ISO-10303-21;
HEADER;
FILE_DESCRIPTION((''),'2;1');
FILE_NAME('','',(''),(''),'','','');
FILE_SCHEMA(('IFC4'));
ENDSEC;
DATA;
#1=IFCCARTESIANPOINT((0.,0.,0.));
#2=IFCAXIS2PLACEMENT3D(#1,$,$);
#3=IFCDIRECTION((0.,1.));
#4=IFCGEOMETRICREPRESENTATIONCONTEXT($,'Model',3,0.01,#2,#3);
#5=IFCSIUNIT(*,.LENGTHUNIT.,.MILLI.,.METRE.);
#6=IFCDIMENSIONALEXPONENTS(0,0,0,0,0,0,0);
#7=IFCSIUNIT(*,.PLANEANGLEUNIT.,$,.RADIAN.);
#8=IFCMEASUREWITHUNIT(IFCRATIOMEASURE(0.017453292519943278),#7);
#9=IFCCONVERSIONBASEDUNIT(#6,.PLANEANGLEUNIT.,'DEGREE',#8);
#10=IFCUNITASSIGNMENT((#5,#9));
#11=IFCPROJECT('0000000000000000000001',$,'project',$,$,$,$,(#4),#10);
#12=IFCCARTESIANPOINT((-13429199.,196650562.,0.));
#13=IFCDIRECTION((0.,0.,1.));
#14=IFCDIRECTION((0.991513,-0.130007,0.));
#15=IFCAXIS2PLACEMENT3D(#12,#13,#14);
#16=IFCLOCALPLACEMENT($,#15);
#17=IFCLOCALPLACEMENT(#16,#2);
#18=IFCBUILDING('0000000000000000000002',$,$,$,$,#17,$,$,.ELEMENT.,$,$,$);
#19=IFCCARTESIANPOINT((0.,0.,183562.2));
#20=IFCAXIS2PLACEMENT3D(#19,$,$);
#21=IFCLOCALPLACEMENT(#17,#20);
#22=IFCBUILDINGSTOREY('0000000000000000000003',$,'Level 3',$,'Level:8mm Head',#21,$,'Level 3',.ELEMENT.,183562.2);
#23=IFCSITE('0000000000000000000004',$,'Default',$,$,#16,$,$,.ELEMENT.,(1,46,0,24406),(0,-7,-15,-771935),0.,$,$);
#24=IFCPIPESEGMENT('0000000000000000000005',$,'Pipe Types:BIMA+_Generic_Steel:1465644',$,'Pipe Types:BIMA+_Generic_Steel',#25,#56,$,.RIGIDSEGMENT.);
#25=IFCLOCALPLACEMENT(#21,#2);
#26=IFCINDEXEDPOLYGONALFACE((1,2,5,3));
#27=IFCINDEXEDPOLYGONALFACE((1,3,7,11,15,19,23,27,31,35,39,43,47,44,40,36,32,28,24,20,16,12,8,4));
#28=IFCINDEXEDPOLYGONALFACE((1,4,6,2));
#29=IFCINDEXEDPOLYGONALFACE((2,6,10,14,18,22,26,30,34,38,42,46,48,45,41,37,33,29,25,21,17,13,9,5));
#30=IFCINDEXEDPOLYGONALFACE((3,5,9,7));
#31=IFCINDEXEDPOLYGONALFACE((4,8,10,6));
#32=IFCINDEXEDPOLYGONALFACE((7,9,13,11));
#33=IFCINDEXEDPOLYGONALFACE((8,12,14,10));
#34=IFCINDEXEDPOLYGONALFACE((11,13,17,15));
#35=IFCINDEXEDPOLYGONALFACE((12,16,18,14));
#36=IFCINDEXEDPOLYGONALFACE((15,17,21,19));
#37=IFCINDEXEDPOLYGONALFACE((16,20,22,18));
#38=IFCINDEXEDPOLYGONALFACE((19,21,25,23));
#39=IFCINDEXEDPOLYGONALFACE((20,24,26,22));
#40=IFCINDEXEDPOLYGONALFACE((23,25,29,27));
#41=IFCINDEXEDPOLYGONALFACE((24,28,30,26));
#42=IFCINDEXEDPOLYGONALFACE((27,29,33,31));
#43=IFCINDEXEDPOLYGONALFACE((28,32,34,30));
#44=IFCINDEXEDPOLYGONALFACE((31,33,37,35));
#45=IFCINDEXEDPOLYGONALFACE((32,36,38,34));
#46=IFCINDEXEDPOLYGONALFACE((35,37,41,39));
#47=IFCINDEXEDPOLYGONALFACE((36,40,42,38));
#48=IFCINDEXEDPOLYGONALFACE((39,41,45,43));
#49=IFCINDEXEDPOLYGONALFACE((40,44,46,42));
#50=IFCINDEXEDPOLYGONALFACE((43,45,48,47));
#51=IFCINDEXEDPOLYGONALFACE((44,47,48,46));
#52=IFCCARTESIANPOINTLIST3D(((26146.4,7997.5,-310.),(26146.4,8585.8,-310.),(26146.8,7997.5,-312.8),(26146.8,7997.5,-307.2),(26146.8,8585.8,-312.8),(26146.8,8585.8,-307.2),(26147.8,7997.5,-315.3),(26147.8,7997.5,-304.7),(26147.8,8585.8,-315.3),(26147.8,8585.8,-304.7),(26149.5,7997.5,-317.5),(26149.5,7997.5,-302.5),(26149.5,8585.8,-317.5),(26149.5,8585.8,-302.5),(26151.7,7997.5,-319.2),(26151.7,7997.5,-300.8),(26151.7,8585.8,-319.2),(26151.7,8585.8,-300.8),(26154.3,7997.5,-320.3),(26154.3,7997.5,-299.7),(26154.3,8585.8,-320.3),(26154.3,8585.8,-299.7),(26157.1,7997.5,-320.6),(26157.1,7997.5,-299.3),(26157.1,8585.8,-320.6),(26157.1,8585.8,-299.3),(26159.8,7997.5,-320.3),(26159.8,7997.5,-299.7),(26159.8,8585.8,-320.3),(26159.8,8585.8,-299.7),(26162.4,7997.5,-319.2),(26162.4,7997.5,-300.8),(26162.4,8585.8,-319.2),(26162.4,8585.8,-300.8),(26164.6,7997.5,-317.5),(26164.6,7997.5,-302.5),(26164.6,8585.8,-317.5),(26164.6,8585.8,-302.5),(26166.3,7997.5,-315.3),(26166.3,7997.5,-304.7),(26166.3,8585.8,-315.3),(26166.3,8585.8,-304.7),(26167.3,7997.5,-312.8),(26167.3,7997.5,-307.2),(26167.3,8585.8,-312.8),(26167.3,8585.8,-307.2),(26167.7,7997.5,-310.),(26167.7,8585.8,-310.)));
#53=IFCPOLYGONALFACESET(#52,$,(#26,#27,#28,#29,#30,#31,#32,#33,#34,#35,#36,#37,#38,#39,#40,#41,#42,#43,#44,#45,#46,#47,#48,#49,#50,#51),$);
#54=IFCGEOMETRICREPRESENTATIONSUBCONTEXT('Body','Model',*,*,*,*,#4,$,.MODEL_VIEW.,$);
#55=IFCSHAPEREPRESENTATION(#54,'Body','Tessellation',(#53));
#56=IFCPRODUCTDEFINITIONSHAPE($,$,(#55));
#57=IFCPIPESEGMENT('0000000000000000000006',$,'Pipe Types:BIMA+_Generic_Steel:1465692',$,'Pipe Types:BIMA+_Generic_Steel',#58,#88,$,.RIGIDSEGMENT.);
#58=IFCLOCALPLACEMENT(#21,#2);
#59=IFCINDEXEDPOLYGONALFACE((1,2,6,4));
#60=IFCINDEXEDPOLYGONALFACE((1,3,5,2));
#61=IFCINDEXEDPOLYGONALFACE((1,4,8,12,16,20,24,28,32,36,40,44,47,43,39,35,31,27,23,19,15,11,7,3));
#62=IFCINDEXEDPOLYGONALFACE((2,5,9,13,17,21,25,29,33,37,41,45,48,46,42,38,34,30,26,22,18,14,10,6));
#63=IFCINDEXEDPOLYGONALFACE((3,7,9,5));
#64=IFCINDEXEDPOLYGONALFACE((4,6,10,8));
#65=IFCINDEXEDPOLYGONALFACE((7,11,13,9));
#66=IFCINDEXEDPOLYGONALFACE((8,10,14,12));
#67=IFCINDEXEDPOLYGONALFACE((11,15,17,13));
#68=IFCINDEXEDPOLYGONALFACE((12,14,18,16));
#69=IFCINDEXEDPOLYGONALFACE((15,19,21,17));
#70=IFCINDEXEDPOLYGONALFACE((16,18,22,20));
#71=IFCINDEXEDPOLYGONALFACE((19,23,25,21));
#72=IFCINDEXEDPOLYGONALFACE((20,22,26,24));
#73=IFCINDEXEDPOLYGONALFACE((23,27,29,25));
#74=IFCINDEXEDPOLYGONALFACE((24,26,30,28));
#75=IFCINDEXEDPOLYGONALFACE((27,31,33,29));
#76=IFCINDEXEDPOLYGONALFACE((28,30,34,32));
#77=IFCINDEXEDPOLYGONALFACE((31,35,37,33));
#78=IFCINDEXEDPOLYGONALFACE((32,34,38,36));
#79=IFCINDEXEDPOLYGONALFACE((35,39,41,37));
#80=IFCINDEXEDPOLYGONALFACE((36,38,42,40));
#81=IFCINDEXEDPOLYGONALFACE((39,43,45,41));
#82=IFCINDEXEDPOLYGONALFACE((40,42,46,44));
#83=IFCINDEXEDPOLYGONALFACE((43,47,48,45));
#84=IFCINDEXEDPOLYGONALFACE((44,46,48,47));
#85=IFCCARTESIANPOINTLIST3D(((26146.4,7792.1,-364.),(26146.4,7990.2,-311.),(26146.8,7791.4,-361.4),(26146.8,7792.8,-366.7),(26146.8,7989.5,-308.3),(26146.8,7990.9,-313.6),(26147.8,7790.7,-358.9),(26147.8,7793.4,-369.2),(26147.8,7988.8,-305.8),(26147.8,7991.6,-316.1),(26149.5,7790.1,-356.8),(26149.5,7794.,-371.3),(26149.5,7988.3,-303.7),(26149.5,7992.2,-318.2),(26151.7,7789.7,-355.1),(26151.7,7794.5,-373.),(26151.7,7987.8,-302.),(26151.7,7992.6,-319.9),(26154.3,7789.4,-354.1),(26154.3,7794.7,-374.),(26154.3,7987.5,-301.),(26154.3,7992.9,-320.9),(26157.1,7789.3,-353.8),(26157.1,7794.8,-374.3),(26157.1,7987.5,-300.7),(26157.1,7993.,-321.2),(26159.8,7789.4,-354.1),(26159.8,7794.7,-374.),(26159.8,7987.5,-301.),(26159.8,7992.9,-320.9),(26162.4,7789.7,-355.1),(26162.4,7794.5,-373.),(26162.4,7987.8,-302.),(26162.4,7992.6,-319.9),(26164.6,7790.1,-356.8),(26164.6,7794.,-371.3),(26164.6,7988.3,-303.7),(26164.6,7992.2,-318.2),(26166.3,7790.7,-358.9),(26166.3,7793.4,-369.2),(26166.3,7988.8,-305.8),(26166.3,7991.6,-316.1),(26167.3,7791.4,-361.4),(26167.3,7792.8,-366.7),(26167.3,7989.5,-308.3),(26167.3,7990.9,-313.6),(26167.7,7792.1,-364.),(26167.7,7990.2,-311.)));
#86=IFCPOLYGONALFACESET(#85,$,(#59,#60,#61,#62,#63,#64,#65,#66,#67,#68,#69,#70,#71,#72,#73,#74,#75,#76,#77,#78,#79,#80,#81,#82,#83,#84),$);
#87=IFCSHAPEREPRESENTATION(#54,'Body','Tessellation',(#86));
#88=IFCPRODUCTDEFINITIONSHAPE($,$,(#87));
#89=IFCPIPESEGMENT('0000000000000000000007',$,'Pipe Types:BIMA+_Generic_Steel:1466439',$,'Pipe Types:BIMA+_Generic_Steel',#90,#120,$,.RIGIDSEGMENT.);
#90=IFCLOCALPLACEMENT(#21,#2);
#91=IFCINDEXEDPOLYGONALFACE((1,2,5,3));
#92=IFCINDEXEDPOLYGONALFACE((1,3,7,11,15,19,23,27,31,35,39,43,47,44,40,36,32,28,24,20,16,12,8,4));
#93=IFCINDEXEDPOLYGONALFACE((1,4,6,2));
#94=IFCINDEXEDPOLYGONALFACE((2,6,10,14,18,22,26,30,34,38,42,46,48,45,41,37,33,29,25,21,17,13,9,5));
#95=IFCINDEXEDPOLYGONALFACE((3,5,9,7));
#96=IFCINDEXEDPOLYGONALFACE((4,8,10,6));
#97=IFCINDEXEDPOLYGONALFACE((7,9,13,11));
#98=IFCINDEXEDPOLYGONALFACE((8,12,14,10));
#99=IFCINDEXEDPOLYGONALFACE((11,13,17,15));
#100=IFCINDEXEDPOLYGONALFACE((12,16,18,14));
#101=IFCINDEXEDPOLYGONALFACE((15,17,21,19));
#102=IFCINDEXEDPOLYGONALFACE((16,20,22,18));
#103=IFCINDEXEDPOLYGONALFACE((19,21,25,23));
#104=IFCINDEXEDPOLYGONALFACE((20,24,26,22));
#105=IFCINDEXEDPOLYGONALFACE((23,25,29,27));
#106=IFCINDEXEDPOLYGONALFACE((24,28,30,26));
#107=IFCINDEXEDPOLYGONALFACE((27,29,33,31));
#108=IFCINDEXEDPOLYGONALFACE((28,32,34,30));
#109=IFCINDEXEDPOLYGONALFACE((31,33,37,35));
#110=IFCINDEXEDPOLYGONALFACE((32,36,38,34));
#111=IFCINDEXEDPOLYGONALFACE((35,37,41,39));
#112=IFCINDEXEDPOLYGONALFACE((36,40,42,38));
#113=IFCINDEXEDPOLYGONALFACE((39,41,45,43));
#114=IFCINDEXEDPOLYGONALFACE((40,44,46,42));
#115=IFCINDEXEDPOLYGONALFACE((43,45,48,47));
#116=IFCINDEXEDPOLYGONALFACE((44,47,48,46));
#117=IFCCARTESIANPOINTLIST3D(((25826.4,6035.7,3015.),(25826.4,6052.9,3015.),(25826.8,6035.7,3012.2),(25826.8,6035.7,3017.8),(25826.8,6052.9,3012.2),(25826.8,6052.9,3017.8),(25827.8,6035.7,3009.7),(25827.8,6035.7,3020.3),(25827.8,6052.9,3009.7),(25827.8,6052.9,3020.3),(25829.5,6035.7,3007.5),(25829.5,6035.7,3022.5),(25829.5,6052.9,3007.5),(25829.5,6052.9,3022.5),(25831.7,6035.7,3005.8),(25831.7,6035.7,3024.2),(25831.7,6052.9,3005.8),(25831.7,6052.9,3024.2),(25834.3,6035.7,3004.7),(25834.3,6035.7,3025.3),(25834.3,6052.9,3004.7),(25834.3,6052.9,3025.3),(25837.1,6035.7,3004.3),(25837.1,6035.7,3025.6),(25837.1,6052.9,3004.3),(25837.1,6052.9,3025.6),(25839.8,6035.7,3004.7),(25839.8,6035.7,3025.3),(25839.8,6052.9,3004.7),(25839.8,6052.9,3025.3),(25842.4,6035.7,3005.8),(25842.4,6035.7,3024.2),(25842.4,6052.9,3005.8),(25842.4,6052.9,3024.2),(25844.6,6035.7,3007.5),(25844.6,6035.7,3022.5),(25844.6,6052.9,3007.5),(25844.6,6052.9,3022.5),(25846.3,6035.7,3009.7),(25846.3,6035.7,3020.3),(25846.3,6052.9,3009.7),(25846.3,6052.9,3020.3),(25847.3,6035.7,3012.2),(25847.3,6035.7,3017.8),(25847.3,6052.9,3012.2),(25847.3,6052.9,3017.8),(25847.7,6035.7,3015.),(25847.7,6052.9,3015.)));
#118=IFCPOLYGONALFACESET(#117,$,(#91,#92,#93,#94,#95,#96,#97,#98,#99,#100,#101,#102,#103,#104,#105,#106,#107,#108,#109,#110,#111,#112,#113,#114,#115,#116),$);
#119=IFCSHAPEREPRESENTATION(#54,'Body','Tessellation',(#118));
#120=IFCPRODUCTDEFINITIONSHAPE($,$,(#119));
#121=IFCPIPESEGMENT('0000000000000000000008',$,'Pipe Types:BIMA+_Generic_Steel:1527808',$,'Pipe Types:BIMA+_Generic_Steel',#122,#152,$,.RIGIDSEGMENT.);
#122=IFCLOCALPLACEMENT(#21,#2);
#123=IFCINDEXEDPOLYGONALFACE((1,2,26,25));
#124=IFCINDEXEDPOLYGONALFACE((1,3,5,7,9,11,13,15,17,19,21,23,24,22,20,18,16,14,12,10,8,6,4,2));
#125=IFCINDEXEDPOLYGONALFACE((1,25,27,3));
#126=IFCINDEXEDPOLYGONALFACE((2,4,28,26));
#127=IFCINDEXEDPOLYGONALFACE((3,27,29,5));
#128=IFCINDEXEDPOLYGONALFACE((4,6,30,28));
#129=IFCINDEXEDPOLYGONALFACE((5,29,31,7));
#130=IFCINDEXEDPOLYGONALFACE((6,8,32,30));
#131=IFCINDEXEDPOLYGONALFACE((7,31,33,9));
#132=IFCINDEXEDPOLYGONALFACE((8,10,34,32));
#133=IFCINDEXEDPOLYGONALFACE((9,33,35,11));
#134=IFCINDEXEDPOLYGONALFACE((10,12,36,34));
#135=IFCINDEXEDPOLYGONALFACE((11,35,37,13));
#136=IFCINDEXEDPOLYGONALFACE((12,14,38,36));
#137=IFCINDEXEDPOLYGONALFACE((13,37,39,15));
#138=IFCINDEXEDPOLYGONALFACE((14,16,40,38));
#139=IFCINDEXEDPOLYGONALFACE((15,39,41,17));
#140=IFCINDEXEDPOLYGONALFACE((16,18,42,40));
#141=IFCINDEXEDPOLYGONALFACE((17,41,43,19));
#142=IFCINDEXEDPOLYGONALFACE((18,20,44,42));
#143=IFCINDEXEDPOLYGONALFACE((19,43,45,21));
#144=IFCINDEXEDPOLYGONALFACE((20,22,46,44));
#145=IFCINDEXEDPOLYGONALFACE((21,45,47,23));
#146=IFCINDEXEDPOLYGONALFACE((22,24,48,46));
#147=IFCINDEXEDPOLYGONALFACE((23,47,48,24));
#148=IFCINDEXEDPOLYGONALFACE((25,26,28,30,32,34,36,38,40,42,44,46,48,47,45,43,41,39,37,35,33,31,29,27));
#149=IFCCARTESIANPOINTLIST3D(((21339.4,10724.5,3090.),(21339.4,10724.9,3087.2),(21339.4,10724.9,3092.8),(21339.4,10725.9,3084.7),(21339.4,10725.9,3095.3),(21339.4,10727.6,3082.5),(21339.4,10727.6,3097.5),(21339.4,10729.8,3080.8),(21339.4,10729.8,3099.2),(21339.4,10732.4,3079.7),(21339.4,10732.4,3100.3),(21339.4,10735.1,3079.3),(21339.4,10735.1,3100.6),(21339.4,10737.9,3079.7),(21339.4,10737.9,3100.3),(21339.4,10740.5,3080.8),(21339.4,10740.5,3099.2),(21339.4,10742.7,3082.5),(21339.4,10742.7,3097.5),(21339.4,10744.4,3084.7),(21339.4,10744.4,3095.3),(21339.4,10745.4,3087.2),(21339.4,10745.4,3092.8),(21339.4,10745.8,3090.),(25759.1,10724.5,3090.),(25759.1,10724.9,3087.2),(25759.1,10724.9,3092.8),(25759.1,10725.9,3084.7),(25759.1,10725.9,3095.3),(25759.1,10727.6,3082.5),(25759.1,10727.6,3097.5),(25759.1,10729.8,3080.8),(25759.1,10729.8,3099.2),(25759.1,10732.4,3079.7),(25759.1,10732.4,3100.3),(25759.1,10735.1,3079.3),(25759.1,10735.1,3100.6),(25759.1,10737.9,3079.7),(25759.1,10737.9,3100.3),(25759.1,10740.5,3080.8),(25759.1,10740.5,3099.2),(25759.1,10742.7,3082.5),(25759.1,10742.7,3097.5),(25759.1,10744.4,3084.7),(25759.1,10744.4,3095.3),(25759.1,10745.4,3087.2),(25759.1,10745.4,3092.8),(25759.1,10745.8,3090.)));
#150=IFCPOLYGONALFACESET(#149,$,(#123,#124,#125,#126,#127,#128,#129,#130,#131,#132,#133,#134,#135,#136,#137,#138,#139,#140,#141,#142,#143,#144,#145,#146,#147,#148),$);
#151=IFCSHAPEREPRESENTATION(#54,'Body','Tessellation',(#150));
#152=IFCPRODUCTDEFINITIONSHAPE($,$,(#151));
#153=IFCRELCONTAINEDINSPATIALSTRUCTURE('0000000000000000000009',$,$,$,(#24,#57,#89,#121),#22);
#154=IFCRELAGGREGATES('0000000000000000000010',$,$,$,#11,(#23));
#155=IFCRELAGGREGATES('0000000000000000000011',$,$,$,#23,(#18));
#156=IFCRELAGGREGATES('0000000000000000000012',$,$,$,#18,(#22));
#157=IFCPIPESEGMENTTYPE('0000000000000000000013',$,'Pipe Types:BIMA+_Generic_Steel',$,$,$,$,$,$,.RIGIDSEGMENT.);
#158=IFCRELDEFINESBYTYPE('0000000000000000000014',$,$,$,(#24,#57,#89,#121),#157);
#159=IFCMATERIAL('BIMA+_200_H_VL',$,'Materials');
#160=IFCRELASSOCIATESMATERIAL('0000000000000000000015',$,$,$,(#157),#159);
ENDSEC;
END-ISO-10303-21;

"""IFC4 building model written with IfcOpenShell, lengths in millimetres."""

from ifc_helpers import new_model, entity, si_unit, converted_unit, direction, frame, origin, place, context, subcontext, project, spatial, arc, indexed_curve, outline, extrude, material, type_object, element, save


model = new_model("IFC4")

# Units and contexts
model_context = context("Model", 3, precision=0.01, world=origin(), true_north=direction((0.0, 1.0)))
body_context = subcontext(model_context, "Body", "Model", "MODEL_VIEW")
ifc_project = project(units=[si_unit("LENGTHUNIT", "METRE", prefix="MILLI"), converted_unit("PLANEANGLEUNIT", "DEGREE", entity("IfcRatioMeasure", 0.017453292519943278), si_unit("PLANEANGLEUNIT", "RADIAN"), dimensions=[0, 0, 0, 0, 0, 0, 0])], contexts=[model_context])

# Site, building, storey
site_placement = place(None, frame((-13429199.0, 196650562.0, 0.0), z_axis=(0.0, 0.0, 1.0), x_axis=(0.991513, -0.130007, 0.0)))
site = spatial("IfcSite", under=ifc_project, at=site_placement, Name="Default", CompositionType="ELEMENT", RefLatitude=(1, 46, 0, 24406), RefLongitude=(0, -7, -15, -771935), RefElevation=0.0)
building_placement = place(site_placement, origin())
building = spatial("IfcBuilding", under=site, at=building_placement, CompositionType="ELEMENT")
storey_placement = place(building_placement, frame((0.0, 0.0, 183562.2)))
storey = spatial("IfcBuildingStorey", under=building, at=storey_placement, Name="Level 3", ObjectType="Level:8mm Head", LongName="Level 3", CompositionType="ELEMENT", Elevation=183562.2)

# Pipe segments
ifc_material_1 = material(Name="BIMA+_200_H_VL", Category="Materials")
pipe_segment_type = type_object("IfcPipeSegmentType", Name="Pipe Types:BIMA+_Generic_Steel", PredefinedType="RIGIDSEGMENT", material=ifc_material_1)
pipe_segment_1_placement = place(storey_placement, frame((26144.8, 7997.5, -322.2)))
element("IfcPipeSegment", 1, at=pipe_segment_1_placement, inside=storey, type_object=pipe_segment_type, Name="Pipe Types:BIMA+_Generic_Steel:1465644", ObjectType="Pipe Types:BIMA+_Generic_Steel", PredefinedType="RIGIDSEGMENT", context=body_context, shape_type="SweptSolid", body=[
    extrude(outline(indexed_curve([(10.7, 0.0), (7.5, 7.5), (0.0, 10.6), (-7.5, 7.5), (-10.7, 0.0), (-7.5, -7.5), (0.0, -10.7), (7.5, -7.5)], segments=[arc(1, 2, 3), arc(3, 4, 5), arc(5, 6, 7), arc(7, 8, 1)], self_intersect=False)), frame((12.2, 0.0, 12.2), z_axis=(0.0, 1.0, 0.0), x_axis=(-1.0, 0.0, 0.0)), (0.0, 0.0, 1.0), 588.3),
])
pipe_segment_2_placement = place(storey_placement, frame((26144.8, 7787.7, -375.9)))
element("IfcPipeSegment", 2, at=pipe_segment_2_placement, inside=storey, type_object=pipe_segment_type, Name="Pipe Types:BIMA+_Generic_Steel:1465692", ObjectType="Pipe Types:BIMA+_Generic_Steel", PredefinedType="RIGIDSEGMENT", context=body_context, shape_type="SweptSolid", body=[
    extrude(outline(indexed_curve([(10.7, 0.0), (7.5, 7.5), (0.0, 10.6), (-7.5, 7.5), (-10.7, 0.0), (-7.5, -7.5), (0.0, -10.7), (7.5, -7.5)], segments=[arc(1, 2, 3), arc(3, 4, 5), arc(5, 6, 7), arc(7, 8, 1)], self_intersect=False)), frame((12.2, 4.4, 11.9), z_axis=(0.0, 0.965926, 0.258819), x_axis=(1.0, 0.0, 0.0)), (0.0, 0.0, 1.0), 205.1),
])
pipe_segment_3_placement = place(storey_placement, frame((25824.8, 6035.7, 3002.8)))
element("IfcPipeSegment", 3, at=pipe_segment_3_placement, inside=storey, type_object=pipe_segment_type, Name="Pipe Types:BIMA+_Generic_Steel:1466439", ObjectType="Pipe Types:BIMA+_Generic_Steel", PredefinedType="RIGIDSEGMENT", context=body_context, shape_type="SweptSolid", body=[
    extrude(outline(indexed_curve([(10.7, 0.0), (7.5, 7.5), (0.0, 10.7), (-7.5, 7.5), (-10.7, 0.0), (-7.5, -7.5), (0.0, -10.7), (7.5, -7.5)], segments=[arc(1, 2, 3), arc(3, 4, 5), arc(5, 6, 7), arc(7, 8, 1)], self_intersect=False)), frame((12.2, 0.0, 12.2), z_axis=(0.0, 1.0, 0.0), x_axis=(1.0, 0.0, 0.0)), (0.0, 0.0, 1.0), 17.2),
])
pipe_segment_4_placement = place(storey_placement, frame((21339.4, 10722.9, 3102.2)))
element("IfcPipeSegment", 4, at=pipe_segment_4_placement, inside=storey, type_object=pipe_segment_type, Name="Pipe Types:BIMA+_Generic_Steel:1527808", ObjectType="Pipe Types:BIMA+_Generic_Steel", PredefinedType="RIGIDSEGMENT", context=body_context, shape_type="SweptSolid", body=[
    extrude(outline(indexed_curve([(10.7, 0.0), (7.5, 7.5), (0.0, 10.7), (-7.5, 7.5), (-10.6, 0.0), (-7.5, -7.5), (0.0, -10.7), (7.5, -7.5)], segments=[arc(1, 2, 3), arc(3, 4, 5), arc(5, 6, 7), arc(7, 8, 1)], self_intersect=False)), frame((0.0, 12.2, -12.2), z_axis=(1.0, 0.0, 0.0), x_axis=(0.0, 1.0, 0.0)), (0.0, 0.0, 1.0), 4419.7),
])

save(model, "model.ifc")
